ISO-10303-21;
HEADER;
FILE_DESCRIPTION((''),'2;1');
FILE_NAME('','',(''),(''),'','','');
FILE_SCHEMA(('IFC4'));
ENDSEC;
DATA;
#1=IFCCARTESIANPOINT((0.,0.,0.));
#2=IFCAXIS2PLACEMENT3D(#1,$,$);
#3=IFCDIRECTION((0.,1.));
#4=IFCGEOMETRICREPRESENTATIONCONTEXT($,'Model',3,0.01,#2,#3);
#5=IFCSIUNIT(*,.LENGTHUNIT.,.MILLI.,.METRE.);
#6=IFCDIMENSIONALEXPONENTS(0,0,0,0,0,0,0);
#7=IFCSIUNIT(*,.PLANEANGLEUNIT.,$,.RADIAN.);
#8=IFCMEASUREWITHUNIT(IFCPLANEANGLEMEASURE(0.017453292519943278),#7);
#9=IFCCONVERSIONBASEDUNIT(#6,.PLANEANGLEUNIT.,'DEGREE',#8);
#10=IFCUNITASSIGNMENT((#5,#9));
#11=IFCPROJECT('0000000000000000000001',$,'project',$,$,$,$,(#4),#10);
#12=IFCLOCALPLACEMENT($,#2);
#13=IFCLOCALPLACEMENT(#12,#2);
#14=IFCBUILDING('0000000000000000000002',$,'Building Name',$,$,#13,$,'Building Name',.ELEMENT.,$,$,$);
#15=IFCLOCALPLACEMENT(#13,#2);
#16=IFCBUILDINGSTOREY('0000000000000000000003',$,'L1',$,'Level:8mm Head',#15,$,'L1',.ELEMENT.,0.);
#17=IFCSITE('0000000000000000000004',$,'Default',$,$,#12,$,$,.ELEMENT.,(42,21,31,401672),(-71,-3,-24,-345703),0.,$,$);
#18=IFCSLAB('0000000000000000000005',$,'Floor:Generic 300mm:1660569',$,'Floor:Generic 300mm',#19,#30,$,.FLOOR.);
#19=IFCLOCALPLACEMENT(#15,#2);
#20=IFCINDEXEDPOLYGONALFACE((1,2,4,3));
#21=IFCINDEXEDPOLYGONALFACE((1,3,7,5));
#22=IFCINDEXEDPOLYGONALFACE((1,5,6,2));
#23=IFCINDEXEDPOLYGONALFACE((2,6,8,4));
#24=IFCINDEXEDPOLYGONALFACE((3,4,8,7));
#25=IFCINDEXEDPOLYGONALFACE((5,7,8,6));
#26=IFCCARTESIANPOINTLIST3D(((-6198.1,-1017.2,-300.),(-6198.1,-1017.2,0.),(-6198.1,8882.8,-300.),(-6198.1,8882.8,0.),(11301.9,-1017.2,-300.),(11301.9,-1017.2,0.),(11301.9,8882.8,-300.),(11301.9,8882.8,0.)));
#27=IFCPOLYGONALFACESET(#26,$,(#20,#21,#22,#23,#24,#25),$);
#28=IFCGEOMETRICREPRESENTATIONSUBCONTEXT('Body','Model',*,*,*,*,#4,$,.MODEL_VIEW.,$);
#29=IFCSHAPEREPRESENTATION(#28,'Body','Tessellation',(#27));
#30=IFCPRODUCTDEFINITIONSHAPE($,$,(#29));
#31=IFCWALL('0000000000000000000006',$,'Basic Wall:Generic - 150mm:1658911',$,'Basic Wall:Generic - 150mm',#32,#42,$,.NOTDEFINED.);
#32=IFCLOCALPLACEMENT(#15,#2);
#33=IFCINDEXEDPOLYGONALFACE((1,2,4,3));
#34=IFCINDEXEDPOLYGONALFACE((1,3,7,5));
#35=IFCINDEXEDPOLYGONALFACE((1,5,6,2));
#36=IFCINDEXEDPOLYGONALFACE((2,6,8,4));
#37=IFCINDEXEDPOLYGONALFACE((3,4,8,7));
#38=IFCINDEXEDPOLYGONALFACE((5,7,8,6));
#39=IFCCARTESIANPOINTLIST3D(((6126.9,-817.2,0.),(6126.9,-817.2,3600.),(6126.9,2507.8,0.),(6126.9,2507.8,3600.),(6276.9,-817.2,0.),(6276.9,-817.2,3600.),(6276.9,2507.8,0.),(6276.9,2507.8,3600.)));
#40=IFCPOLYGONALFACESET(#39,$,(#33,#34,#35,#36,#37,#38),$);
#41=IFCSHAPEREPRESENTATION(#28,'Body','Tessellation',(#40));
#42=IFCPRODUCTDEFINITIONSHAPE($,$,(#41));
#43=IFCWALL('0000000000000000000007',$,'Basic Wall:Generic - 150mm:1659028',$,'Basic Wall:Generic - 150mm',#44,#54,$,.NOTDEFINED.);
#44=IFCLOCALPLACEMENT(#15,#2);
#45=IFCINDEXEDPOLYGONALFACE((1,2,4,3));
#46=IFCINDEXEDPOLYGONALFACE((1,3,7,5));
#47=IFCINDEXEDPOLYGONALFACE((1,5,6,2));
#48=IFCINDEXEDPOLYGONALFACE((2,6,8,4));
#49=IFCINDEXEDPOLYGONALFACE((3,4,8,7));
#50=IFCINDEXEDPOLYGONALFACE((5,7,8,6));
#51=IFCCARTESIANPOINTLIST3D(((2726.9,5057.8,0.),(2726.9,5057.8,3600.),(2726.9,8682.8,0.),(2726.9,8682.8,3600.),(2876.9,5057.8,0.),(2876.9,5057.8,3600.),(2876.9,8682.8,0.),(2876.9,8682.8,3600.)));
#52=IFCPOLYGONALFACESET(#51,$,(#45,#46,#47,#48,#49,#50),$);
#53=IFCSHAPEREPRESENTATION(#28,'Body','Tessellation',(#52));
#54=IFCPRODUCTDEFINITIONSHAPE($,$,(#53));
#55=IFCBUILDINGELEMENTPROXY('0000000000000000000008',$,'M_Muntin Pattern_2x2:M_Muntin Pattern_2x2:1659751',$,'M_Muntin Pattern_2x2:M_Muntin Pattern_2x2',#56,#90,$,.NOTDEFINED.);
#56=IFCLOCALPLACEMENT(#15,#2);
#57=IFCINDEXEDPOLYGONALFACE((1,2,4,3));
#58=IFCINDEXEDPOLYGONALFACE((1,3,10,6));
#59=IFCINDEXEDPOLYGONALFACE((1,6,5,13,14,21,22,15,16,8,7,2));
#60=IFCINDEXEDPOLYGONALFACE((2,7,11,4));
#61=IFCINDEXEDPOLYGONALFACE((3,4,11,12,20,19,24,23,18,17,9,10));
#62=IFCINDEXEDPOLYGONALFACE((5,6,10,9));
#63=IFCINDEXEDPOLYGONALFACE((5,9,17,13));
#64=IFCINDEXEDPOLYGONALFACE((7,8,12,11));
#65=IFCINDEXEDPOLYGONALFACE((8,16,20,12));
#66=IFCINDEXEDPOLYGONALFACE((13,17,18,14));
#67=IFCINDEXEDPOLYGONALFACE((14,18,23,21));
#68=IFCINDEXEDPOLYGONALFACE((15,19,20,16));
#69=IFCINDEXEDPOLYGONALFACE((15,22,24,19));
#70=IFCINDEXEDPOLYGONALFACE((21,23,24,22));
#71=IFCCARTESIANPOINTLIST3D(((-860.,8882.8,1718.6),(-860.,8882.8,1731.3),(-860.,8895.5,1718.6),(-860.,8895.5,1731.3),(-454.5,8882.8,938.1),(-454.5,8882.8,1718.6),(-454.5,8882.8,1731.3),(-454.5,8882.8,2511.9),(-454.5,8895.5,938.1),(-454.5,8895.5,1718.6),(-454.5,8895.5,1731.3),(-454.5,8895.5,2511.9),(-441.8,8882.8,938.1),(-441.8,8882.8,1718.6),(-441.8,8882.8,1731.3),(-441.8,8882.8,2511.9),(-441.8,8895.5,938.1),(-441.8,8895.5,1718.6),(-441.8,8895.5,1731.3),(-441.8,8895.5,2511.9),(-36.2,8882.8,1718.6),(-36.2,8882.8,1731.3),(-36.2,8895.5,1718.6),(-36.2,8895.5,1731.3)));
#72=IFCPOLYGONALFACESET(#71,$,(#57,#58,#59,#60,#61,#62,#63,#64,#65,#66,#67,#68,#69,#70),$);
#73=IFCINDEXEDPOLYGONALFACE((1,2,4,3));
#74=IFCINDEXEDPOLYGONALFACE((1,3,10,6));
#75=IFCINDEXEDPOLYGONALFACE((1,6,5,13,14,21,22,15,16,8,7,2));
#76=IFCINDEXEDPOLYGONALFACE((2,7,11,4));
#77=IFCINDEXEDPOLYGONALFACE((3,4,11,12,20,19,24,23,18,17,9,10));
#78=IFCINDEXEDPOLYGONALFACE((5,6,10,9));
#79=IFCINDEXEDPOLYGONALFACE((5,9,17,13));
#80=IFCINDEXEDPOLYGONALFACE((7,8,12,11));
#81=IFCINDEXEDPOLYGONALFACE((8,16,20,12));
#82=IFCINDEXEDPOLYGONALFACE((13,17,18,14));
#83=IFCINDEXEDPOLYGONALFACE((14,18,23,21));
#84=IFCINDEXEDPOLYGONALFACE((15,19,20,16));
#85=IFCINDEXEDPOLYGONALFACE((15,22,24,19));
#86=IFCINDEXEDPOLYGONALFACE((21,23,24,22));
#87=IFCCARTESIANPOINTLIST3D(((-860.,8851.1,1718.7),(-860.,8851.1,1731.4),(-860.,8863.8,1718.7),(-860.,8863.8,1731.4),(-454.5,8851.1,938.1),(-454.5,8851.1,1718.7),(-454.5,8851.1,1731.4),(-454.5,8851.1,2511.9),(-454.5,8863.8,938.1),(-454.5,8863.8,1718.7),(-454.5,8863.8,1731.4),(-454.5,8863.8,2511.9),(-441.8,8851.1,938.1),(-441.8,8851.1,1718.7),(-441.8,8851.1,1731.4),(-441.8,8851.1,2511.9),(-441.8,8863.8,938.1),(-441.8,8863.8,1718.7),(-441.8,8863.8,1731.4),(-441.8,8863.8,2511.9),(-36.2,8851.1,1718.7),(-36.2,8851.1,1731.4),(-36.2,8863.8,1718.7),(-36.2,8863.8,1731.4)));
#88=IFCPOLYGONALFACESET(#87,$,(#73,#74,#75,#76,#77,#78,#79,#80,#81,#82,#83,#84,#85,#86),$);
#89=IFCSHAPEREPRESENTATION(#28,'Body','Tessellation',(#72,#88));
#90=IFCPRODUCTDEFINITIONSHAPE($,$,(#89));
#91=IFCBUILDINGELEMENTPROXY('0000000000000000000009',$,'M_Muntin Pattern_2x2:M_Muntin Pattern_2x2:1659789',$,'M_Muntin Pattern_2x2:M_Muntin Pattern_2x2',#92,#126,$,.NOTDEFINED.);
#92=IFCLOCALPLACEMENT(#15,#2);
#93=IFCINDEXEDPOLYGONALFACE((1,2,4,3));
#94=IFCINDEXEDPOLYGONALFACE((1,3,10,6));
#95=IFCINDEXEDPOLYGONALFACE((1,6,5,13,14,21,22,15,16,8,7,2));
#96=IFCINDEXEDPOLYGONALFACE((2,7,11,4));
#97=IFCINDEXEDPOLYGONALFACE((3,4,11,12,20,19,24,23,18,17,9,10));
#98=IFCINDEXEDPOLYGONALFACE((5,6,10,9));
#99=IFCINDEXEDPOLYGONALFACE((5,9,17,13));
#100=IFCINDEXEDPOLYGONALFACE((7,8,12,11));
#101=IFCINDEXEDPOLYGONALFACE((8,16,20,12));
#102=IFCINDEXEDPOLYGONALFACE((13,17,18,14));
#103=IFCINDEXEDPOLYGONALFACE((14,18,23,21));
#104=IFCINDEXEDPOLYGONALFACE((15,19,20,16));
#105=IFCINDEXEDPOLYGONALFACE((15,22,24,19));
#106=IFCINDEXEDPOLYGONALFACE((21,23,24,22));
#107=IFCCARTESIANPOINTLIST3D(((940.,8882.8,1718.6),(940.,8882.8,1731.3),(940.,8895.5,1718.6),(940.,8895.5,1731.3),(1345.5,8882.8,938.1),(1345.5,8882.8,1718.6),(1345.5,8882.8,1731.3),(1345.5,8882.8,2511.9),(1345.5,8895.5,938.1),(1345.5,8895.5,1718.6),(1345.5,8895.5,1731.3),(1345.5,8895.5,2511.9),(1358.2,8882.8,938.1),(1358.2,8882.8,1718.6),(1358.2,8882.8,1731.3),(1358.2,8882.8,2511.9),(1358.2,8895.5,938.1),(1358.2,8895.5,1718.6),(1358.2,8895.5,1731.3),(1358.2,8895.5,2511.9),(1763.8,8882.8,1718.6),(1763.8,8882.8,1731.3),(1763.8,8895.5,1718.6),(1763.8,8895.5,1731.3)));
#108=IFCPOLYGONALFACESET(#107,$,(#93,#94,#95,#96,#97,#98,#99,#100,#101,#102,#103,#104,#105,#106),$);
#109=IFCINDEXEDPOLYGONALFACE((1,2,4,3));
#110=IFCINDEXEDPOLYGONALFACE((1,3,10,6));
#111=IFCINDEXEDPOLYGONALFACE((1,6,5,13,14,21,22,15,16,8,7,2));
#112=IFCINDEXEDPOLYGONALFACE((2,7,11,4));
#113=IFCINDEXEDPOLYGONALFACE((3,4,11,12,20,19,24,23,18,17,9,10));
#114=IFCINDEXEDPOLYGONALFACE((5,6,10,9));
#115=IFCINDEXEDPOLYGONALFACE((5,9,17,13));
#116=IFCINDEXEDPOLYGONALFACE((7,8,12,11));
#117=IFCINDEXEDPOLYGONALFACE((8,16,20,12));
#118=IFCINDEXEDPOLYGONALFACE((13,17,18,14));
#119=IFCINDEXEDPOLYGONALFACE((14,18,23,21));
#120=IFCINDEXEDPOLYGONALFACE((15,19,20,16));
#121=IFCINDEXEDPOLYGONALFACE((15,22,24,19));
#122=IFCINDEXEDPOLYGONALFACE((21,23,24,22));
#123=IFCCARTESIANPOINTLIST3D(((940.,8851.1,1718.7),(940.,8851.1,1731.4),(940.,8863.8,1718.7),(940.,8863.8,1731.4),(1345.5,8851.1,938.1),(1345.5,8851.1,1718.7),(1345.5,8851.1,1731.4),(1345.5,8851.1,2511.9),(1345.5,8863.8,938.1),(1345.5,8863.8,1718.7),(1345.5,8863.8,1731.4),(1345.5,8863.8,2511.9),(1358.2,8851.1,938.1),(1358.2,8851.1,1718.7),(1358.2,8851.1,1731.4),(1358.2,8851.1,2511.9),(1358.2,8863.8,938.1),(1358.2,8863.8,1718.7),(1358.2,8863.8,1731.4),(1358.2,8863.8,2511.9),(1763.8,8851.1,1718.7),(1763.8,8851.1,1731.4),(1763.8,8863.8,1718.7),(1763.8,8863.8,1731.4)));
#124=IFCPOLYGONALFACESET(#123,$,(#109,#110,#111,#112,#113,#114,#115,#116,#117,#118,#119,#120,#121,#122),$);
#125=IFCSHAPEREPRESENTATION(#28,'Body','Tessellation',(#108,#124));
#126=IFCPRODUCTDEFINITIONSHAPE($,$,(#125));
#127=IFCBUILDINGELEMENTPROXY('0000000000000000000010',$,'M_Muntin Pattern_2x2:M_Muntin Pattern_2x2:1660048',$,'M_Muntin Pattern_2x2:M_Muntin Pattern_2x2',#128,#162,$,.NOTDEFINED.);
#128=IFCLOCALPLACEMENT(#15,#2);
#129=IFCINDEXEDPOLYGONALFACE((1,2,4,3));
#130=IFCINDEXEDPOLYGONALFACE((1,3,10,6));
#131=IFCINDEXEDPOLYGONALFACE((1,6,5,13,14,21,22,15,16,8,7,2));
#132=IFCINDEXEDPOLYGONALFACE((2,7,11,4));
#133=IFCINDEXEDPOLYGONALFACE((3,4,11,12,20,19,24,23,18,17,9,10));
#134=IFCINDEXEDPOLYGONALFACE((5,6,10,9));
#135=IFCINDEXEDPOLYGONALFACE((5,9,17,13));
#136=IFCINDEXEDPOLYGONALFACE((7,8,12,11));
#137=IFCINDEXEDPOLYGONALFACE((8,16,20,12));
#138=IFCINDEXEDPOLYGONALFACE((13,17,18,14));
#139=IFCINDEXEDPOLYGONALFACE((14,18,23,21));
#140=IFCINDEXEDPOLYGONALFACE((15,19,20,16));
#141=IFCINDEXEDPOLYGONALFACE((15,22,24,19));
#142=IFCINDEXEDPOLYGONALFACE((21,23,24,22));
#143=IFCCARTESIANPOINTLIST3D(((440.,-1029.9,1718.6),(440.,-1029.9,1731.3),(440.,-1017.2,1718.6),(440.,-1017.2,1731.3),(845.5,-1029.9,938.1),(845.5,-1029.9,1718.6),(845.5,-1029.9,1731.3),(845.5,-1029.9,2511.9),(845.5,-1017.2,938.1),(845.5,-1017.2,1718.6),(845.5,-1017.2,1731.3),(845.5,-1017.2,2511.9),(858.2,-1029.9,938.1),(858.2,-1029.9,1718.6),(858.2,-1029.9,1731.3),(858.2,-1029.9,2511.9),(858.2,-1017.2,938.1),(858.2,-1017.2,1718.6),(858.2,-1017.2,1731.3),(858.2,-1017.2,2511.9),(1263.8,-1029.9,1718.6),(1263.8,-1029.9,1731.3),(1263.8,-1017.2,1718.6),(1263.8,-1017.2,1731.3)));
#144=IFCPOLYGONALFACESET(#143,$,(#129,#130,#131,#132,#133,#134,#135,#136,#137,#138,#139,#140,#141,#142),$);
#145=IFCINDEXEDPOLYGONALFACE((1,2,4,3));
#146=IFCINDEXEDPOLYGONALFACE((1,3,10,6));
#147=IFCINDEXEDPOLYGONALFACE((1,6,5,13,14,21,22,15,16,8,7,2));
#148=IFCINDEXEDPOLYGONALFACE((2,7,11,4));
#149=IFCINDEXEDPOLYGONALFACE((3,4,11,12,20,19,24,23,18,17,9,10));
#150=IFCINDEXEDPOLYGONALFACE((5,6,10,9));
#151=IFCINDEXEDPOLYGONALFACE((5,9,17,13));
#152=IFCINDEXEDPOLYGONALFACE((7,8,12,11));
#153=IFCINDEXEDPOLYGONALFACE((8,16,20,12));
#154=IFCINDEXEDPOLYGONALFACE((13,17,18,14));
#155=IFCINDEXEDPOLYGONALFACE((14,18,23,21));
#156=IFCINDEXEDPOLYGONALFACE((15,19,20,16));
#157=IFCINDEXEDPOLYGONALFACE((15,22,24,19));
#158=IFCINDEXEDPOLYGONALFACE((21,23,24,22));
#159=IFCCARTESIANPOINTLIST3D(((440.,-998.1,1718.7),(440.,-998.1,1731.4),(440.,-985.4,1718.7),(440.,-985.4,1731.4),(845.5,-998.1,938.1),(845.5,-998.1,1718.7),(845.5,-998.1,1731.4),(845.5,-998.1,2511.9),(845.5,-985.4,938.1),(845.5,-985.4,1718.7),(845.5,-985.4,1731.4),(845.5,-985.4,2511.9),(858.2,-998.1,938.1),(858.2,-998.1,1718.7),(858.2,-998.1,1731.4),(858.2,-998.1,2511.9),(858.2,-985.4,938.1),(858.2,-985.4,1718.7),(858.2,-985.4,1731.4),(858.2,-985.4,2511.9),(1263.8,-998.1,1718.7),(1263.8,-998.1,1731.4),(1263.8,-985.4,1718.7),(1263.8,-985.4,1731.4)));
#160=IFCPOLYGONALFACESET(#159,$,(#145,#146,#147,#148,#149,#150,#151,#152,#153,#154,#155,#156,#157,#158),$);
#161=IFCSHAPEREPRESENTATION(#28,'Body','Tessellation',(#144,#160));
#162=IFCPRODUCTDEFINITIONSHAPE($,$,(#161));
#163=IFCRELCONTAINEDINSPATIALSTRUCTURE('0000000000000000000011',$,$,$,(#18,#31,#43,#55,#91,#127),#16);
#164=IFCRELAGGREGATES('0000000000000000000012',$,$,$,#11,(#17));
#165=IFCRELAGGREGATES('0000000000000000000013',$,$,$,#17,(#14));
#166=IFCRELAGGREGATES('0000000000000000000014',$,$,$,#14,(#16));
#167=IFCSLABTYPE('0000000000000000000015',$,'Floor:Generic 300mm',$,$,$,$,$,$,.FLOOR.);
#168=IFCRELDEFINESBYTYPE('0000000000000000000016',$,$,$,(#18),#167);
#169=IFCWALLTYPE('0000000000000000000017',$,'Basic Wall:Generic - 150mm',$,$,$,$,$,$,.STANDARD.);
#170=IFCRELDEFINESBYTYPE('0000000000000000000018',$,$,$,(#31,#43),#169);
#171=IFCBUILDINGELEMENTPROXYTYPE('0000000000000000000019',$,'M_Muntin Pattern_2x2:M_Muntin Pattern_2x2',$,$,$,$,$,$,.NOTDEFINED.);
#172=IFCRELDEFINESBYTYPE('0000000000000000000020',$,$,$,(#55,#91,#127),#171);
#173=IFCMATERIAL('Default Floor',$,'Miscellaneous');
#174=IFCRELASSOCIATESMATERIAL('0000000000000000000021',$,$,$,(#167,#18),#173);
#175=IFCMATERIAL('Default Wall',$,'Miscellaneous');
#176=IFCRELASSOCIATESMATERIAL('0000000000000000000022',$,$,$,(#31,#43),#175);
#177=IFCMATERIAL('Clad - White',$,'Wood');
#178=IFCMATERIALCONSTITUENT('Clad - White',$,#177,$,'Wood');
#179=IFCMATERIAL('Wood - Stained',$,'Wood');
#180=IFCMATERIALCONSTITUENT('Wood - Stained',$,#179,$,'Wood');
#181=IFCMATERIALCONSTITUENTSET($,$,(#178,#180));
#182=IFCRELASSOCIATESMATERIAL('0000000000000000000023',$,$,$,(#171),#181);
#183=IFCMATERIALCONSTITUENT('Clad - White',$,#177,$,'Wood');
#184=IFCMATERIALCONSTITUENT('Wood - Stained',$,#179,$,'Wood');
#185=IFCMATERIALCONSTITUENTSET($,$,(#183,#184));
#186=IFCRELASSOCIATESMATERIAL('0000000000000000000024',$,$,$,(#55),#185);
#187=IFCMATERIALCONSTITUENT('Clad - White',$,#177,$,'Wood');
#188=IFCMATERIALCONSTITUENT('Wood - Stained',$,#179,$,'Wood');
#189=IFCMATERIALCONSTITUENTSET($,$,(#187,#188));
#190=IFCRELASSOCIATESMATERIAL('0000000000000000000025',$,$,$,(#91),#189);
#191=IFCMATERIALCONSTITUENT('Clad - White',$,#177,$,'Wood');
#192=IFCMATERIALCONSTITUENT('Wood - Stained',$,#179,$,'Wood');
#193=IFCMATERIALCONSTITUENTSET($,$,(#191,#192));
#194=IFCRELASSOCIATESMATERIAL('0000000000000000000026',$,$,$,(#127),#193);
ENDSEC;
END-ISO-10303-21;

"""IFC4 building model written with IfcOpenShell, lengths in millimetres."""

from ifc_helpers import new_model, entity, si_unit, converted_unit, direction, frame, origin, place, context, subcontext, project, spatial, indexed_curve, outline, extrude, source, transform, mapped, material, constituent, constituent_set, type_object, type_shapes, element, save


model = new_model("IFC4")

# Units and contexts
model_context = context("Model", 3, precision=0.01, world=origin(), true_north=direction((0.0, 1.0)))
body_context = subcontext(model_context, "Body", "Model", "MODEL_VIEW")
ifc_project = project(units=[si_unit("LENGTHUNIT", "METRE", prefix="MILLI"), converted_unit("PLANEANGLEUNIT", "DEGREE", entity("IfcPlaneAngleMeasure", 0.017453292519943278), si_unit("PLANEANGLEUNIT", "RADIAN"), dimensions=[0, 0, 0, 0, 0, 0, 0])], contexts=[model_context])

# Site, building, storey
site_placement = place(None, origin())
site = spatial("IfcSite", under=ifc_project, at=site_placement, Name="Default", CompositionType="ELEMENT", RefLatitude=(42, 21, 31, 401672), RefLongitude=(-71, -3, -24, -345703), RefElevation=0.0)
building_placement = place(site_placement, origin())
building = spatial("IfcBuilding", under=site, at=building_placement, Name="Building Name", LongName="Building Name", CompositionType="ELEMENT")
storey_placement = place(building_placement, origin())
storey = spatial("IfcBuildingStorey", under=building, at=storey_placement, Name="L1", ObjectType="Level:8mm Head", LongName="L1", CompositionType="ELEMENT", Elevation=0.0)

# Slab
ifc_material_1 = material(Name="Default Floor", Category="Miscellaneous")
slab_type = type_object("IfcSlabType", Name="Floor:Generic 300mm", PredefinedType="FLOOR", material=ifc_material_1)
slab_placement = place(storey_placement, origin())
element("IfcSlab", 1, at=slab_placement, inside=storey, type_object=slab_type, material=ifc_material_1, Name="Floor:Generic 300mm:1660569", ObjectType="Floor:Generic 300mm", PredefinedType="FLOOR", context=body_context, shape_type="SweptSolid", body=[
    extrude(outline(indexed_curve([(-4950.0, -8750.0), (4950.0, -8750.0), (4950.0, 8750.0), (-4950.0, 8750.0), (-4950.0, -8750.0)], self_intersect=False)), frame((2551.9, 3932.8, 0.0), z_axis=(0.0, 0.0, -1.0), x_axis=(0.0, 1.0, 0.0)), (0.0, 0.0, 1.0), 300.0),
])

# Walls
ifc_material_2 = material(Name="Default Wall", Category="Miscellaneous")
wall_type = type_object("IfcWallType", Name="Basic Wall:Generic - 150mm", PredefinedType="STANDARD")
wall_1_placement = place(storey_placement, frame((6201.9, 2507.8, 0.0), z_axis=(0.0, 0.0, 1.0), x_axis=(0.0, -1.0, 0.0)))
element("IfcWall", 2, at=wall_1_placement, inside=storey, type_object=wall_type, material=ifc_material_2, Name="Basic Wall:Generic - 150mm:1658911", ObjectType="Basic Wall:Generic - 150mm", PredefinedType="NOTDEFINED", context=body_context, shape_type="SweptSolid", body=[
    extrude(outline(indexed_curve([(3325.0, 75.0), (0.0, 75.0), (0.0, -75.0), (3325.0, -75.0), (3325.0, 75.0)], self_intersect=False)), origin(), (0.0, 0.0, 1.0), 3600.0),
])
wall_2_placement = place(storey_placement, frame((2801.9, 5057.8, 0.0), z_axis=(0.0, 0.0, 1.0), x_axis=(0.0, 1.0, 0.0)))
element("IfcWall", 3, at=wall_2_placement, inside=storey, type_object=wall_type, material=ifc_material_2, Name="Basic Wall:Generic - 150mm:1659028", ObjectType="Basic Wall:Generic - 150mm", PredefinedType="NOTDEFINED", context=body_context, shape_type="SweptSolid", body=[
    extrude(outline(indexed_curve([(3625.0, 75.0), (0.0, 75.0), (0.0, -75.0), (3625.0, -75.0), (3625.0, 75.0)], self_intersect=False)), origin(), (0.0, 0.0, 1.0), 3600.0),
])

# Building element proxies
ifc_material_3 = material(Name="Clad - White", Category="Wood")
ifc_constituent_1 = constituent(ifc_material_3, Name="Clad - White", Category="Wood")
ifc_material_4 = material(Name="Wood - Stained", Category="Wood")
ifc_constituent_2 = constituent(ifc_material_4, Name="Wood - Stained", Category="Wood")
ifc_constituent_set_1 = constituent_set(constituents=[ifc_constituent_1, ifc_constituent_2])
ifc_constituent_3 = constituent(ifc_material_3, Name="Clad - White", Category="Wood")
ifc_constituent_4 = constituent(ifc_material_4, Name="Wood - Stained", Category="Wood")
ifc_constituent_set_2 = constituent_set(constituents=[ifc_constituent_3, ifc_constituent_4])
building_element_proxy_type_1 = type_object("IfcBuildingElementProxyType", Name="M_Muntin Pattern_2x2:M_Muntin Pattern_2x2", PredefinedType="NOTDEFINED", material=ifc_constituent_set_2)
shared_shape_1 = source(origin(), body_context, "Body", "SweptSolid", [
    extrude(outline(indexed_curve([(6.4, -6.4), (786.9, -6.4), (786.9, 6.3), (6.4, 6.3), (6.4, 411.9), (-6.3, 411.9), (-6.3, 6.3), (-786.9, 6.3), (-786.9, -6.4), (-6.3, -6.4), (-6.3, -411.9), (6.4, -411.9), (6.4, -6.4)], self_intersect=False)), frame((0.0, -22.2, 786.9), z_axis=(0.0, 1.0, 0.0), x_axis=(0.0, 0.0, 1.0)), (0.0, 0.0, 1.0), 12.7),
    extrude(outline(indexed_curve([(6.4, -6.4), (786.9, -6.4), (786.9, 6.3), (6.4, 6.3), (6.4, 411.9), (-6.3, 411.9), (-6.3, 6.3), (-786.9, 6.3), (-786.9, -6.4), (-6.3, -6.4), (-6.3, -411.9), (6.4, -411.9), (6.4, -6.4)], self_intersect=False)), frame((0.0, 9.5, 786.9), z_axis=(0.0, 1.0, 0.0), x_axis=(0.0, 0.0, 1.0)), (0.0, 0.0, 1.0), 12.7),
])
type_shapes(building_element_proxy_type_1, [shared_shape_1])
proxy_1_placement = place(storey_placement, frame((-448.1, 8873.3, 938.1), z_axis=(0.0, 0.0, 1.0), x_axis=(-1.0, 0.0, 0.0)))
element("IfcBuildingElementProxy", 4, at=proxy_1_placement, inside=storey, type_object=building_element_proxy_type_1, material=ifc_constituent_set_1, Name="M_Muntin Pattern_2x2:M_Muntin Pattern_2x2:1659751", ObjectType="M_Muntin Pattern_2x2:M_Muntin Pattern_2x2", PredefinedType="NOTDEFINED", context=body_context, shape_type="MappedRepresentation", body=[
    mapped(shared_shape_1, transform((0.0, 0.0, 0.0), scale=1.0)),
])
ifc_constituent_5 = constituent(ifc_material_3, Name="Clad - White", Category="Wood")
ifc_constituent_6 = constituent(ifc_material_4, Name="Wood - Stained", Category="Wood")
ifc_constituent_set_3 = constituent_set(constituents=[ifc_constituent_5, ifc_constituent_6])
proxy_2_placement = place(storey_placement, frame((1351.9, 8873.3, 938.1), z_axis=(0.0, 0.0, 1.0), x_axis=(-1.0, 0.0, 0.0)))
element("IfcBuildingElementProxy", 5, at=proxy_2_placement, inside=storey, type_object=building_element_proxy_type_1, material=ifc_constituent_set_3, Name="M_Muntin Pattern_2x2:M_Muntin Pattern_2x2:1659789", ObjectType="M_Muntin Pattern_2x2:M_Muntin Pattern_2x2", PredefinedType="NOTDEFINED", context=body_context, shape_type="MappedRepresentation", body=[
    mapped(shared_shape_1, transform((0.0, 0.0, 0.0), scale=1.0)),
])
ifc_constituent_7 = constituent(ifc_material_3, Name="Clad - White", Category="Wood")
ifc_constituent_8 = constituent(ifc_material_4, Name="Wood - Stained", Category="Wood")
ifc_constituent_set_4 = constituent_set(constituents=[ifc_constituent_7, ifc_constituent_8])
proxy_3_placement = place(storey_placement, frame((851.9, -1007.7, 938.1)))
element("IfcBuildingElementProxy", 6, at=proxy_3_placement, inside=storey, type_object=building_element_proxy_type_1, material=ifc_constituent_set_4, Name="M_Muntin Pattern_2x2:M_Muntin Pattern_2x2:1660048", ObjectType="M_Muntin Pattern_2x2:M_Muntin Pattern_2x2", PredefinedType="NOTDEFINED", context=body_context, shape_type="MappedRepresentation", body=[
    mapped(shared_shape_1, transform((0.0, 0.0, 0.0), scale=1.0)),
])

save(model, "model.ifc")
